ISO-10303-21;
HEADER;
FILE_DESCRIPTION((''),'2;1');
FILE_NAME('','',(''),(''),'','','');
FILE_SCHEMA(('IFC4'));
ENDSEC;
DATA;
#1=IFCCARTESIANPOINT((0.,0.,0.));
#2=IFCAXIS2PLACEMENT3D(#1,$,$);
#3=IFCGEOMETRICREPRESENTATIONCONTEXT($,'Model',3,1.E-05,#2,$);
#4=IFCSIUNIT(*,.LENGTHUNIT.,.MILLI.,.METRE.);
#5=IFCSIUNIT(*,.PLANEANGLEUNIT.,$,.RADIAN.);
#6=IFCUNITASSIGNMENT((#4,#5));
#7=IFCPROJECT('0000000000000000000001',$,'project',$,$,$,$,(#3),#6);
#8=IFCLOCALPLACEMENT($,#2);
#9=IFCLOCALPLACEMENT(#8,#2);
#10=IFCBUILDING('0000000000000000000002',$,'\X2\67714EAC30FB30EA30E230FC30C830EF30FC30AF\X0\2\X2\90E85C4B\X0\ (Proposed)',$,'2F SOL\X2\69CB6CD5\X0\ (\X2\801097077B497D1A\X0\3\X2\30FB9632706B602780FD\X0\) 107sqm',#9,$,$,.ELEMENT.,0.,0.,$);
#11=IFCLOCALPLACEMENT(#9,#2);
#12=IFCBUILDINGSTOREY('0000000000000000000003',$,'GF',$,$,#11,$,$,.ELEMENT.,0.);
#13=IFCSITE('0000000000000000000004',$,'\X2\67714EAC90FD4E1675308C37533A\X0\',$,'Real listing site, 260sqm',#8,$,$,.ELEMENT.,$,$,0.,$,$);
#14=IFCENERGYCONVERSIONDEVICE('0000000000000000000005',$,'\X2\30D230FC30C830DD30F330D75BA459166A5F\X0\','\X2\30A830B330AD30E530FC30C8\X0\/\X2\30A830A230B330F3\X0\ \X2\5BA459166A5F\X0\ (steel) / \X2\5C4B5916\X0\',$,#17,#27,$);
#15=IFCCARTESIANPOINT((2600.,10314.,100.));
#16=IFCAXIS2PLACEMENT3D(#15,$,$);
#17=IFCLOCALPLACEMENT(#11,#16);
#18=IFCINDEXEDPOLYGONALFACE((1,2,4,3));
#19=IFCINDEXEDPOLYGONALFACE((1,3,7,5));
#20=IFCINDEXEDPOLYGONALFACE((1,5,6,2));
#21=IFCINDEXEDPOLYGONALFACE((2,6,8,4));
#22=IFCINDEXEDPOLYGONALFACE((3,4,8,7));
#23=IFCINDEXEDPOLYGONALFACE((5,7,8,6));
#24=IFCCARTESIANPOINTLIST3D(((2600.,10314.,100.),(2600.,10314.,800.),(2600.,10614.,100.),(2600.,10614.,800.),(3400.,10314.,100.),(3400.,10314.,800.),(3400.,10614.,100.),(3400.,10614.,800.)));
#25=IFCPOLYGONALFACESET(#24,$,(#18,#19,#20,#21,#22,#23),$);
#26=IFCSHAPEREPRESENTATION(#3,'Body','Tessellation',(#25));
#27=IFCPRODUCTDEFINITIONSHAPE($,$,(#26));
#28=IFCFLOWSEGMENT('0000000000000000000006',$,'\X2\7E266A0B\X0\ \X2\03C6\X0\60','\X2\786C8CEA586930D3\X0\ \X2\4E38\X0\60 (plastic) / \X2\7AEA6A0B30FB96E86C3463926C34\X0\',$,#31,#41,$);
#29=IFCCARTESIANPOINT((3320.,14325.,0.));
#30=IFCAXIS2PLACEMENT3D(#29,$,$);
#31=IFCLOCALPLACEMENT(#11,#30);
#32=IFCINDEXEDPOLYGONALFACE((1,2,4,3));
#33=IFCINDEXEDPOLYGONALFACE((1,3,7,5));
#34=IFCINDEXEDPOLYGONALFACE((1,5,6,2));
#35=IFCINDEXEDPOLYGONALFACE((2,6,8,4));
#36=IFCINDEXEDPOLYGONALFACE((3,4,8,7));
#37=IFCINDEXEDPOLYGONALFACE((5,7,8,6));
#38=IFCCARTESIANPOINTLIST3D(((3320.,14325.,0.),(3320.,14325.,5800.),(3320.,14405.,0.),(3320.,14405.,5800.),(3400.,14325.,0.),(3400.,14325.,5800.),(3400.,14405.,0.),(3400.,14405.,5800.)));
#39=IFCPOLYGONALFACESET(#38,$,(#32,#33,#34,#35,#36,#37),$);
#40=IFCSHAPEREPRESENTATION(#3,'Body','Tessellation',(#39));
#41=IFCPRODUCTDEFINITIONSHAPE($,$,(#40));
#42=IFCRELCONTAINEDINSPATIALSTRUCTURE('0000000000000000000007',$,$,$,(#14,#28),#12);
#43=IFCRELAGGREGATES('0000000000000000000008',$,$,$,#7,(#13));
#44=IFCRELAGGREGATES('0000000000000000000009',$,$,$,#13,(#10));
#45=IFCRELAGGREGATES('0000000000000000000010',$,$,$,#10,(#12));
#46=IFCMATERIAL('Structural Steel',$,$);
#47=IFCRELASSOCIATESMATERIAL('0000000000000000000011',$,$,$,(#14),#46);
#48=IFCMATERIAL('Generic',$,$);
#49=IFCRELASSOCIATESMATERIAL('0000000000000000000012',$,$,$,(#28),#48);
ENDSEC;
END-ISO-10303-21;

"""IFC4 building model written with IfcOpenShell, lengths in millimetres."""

from ifc_helpers import new_model, si_unit, frame, frame_2d, origin, place, context, project, spatial, rectangle, extrude, material, element, save


model = new_model("IFC4")

# Units and contexts
model_context = context("Model", 3, precision=1e-05, world=origin())
ifc_project = project(units=[si_unit("LENGTHUNIT", "METRE", prefix="MILLI"), si_unit("PLANEANGLEUNIT", "RADIAN")], contexts=[model_context])

# Site, building, storey
site_placement = place(None, origin())
site = spatial("IfcSite", under=ifc_project, at=site_placement, Name="東京都世田谷区", ObjectType="Real listing site, 260sqm", CompositionType="ELEMENT", RefElevation=0.0)
building_placement = place(site_placement, origin())
building = spatial("IfcBuilding", under=site, at=building_placement, Name="東京・リモートワーク2部屋 (Proposed)", ObjectType="2F SOL構法 (耐震等級3・防火性能) 107sqm", CompositionType="ELEMENT", ElevationOfRefHeight=0.0, ElevationOfTerrain=0.0)
storey_placement = place(building_placement, origin())
storey = spatial("IfcBuildingStorey", under=building, at=storey_placement, Name="GF", CompositionType="ELEMENT", Elevation=0.0)

# Shared definitions
ifc_material_1 = material(Name="Generic")

# Energy conversion device
ifc_material_2 = material(Name="Structural Steel")
energy_conversion_device_placement = place(storey_placement, frame((2600.0, 10314.0, 100.0)))
element("IfcEnergyConversionDevice", 1, at=energy_conversion_device_placement, inside=storey, material=ifc_material_2, Name="ヒートポンプ室外機", Description="エコキュート/エアコン 室外機 (steel) / 屋外", context=model_context, shape_type="SweptSolid", body=[
    extrude(rectangle(XDim=800.0, YDim=300.0, at=frame_2d((400.0, 150.0))), frame((2600.0, 10314.0, 100.0)), (0.0, 0.0, 1.0), 700.0),
])

# Flow segment
flow_segment_placement = place(storey_placement, frame((3320.0, 14325.0, 0.0)))
element("IfcFlowSegment", 2, at=flow_segment_placement, inside=storey, material=ifc_material_1, Name="縦樋 φ60", Description="硬質塩ビ 丸60 (plastic) / 竪樋・雨水排水", context=model_context, shape_type="SweptSolid", body=[
    extrude(rectangle(XDim=80.0, YDim=80.0, at=frame_2d((40.0, 40.0))), frame((3320.0, 14325.0, 0.0)), (0.0, 0.0, 1.0), 5800.0),
])

save(model, "model.ifc")
